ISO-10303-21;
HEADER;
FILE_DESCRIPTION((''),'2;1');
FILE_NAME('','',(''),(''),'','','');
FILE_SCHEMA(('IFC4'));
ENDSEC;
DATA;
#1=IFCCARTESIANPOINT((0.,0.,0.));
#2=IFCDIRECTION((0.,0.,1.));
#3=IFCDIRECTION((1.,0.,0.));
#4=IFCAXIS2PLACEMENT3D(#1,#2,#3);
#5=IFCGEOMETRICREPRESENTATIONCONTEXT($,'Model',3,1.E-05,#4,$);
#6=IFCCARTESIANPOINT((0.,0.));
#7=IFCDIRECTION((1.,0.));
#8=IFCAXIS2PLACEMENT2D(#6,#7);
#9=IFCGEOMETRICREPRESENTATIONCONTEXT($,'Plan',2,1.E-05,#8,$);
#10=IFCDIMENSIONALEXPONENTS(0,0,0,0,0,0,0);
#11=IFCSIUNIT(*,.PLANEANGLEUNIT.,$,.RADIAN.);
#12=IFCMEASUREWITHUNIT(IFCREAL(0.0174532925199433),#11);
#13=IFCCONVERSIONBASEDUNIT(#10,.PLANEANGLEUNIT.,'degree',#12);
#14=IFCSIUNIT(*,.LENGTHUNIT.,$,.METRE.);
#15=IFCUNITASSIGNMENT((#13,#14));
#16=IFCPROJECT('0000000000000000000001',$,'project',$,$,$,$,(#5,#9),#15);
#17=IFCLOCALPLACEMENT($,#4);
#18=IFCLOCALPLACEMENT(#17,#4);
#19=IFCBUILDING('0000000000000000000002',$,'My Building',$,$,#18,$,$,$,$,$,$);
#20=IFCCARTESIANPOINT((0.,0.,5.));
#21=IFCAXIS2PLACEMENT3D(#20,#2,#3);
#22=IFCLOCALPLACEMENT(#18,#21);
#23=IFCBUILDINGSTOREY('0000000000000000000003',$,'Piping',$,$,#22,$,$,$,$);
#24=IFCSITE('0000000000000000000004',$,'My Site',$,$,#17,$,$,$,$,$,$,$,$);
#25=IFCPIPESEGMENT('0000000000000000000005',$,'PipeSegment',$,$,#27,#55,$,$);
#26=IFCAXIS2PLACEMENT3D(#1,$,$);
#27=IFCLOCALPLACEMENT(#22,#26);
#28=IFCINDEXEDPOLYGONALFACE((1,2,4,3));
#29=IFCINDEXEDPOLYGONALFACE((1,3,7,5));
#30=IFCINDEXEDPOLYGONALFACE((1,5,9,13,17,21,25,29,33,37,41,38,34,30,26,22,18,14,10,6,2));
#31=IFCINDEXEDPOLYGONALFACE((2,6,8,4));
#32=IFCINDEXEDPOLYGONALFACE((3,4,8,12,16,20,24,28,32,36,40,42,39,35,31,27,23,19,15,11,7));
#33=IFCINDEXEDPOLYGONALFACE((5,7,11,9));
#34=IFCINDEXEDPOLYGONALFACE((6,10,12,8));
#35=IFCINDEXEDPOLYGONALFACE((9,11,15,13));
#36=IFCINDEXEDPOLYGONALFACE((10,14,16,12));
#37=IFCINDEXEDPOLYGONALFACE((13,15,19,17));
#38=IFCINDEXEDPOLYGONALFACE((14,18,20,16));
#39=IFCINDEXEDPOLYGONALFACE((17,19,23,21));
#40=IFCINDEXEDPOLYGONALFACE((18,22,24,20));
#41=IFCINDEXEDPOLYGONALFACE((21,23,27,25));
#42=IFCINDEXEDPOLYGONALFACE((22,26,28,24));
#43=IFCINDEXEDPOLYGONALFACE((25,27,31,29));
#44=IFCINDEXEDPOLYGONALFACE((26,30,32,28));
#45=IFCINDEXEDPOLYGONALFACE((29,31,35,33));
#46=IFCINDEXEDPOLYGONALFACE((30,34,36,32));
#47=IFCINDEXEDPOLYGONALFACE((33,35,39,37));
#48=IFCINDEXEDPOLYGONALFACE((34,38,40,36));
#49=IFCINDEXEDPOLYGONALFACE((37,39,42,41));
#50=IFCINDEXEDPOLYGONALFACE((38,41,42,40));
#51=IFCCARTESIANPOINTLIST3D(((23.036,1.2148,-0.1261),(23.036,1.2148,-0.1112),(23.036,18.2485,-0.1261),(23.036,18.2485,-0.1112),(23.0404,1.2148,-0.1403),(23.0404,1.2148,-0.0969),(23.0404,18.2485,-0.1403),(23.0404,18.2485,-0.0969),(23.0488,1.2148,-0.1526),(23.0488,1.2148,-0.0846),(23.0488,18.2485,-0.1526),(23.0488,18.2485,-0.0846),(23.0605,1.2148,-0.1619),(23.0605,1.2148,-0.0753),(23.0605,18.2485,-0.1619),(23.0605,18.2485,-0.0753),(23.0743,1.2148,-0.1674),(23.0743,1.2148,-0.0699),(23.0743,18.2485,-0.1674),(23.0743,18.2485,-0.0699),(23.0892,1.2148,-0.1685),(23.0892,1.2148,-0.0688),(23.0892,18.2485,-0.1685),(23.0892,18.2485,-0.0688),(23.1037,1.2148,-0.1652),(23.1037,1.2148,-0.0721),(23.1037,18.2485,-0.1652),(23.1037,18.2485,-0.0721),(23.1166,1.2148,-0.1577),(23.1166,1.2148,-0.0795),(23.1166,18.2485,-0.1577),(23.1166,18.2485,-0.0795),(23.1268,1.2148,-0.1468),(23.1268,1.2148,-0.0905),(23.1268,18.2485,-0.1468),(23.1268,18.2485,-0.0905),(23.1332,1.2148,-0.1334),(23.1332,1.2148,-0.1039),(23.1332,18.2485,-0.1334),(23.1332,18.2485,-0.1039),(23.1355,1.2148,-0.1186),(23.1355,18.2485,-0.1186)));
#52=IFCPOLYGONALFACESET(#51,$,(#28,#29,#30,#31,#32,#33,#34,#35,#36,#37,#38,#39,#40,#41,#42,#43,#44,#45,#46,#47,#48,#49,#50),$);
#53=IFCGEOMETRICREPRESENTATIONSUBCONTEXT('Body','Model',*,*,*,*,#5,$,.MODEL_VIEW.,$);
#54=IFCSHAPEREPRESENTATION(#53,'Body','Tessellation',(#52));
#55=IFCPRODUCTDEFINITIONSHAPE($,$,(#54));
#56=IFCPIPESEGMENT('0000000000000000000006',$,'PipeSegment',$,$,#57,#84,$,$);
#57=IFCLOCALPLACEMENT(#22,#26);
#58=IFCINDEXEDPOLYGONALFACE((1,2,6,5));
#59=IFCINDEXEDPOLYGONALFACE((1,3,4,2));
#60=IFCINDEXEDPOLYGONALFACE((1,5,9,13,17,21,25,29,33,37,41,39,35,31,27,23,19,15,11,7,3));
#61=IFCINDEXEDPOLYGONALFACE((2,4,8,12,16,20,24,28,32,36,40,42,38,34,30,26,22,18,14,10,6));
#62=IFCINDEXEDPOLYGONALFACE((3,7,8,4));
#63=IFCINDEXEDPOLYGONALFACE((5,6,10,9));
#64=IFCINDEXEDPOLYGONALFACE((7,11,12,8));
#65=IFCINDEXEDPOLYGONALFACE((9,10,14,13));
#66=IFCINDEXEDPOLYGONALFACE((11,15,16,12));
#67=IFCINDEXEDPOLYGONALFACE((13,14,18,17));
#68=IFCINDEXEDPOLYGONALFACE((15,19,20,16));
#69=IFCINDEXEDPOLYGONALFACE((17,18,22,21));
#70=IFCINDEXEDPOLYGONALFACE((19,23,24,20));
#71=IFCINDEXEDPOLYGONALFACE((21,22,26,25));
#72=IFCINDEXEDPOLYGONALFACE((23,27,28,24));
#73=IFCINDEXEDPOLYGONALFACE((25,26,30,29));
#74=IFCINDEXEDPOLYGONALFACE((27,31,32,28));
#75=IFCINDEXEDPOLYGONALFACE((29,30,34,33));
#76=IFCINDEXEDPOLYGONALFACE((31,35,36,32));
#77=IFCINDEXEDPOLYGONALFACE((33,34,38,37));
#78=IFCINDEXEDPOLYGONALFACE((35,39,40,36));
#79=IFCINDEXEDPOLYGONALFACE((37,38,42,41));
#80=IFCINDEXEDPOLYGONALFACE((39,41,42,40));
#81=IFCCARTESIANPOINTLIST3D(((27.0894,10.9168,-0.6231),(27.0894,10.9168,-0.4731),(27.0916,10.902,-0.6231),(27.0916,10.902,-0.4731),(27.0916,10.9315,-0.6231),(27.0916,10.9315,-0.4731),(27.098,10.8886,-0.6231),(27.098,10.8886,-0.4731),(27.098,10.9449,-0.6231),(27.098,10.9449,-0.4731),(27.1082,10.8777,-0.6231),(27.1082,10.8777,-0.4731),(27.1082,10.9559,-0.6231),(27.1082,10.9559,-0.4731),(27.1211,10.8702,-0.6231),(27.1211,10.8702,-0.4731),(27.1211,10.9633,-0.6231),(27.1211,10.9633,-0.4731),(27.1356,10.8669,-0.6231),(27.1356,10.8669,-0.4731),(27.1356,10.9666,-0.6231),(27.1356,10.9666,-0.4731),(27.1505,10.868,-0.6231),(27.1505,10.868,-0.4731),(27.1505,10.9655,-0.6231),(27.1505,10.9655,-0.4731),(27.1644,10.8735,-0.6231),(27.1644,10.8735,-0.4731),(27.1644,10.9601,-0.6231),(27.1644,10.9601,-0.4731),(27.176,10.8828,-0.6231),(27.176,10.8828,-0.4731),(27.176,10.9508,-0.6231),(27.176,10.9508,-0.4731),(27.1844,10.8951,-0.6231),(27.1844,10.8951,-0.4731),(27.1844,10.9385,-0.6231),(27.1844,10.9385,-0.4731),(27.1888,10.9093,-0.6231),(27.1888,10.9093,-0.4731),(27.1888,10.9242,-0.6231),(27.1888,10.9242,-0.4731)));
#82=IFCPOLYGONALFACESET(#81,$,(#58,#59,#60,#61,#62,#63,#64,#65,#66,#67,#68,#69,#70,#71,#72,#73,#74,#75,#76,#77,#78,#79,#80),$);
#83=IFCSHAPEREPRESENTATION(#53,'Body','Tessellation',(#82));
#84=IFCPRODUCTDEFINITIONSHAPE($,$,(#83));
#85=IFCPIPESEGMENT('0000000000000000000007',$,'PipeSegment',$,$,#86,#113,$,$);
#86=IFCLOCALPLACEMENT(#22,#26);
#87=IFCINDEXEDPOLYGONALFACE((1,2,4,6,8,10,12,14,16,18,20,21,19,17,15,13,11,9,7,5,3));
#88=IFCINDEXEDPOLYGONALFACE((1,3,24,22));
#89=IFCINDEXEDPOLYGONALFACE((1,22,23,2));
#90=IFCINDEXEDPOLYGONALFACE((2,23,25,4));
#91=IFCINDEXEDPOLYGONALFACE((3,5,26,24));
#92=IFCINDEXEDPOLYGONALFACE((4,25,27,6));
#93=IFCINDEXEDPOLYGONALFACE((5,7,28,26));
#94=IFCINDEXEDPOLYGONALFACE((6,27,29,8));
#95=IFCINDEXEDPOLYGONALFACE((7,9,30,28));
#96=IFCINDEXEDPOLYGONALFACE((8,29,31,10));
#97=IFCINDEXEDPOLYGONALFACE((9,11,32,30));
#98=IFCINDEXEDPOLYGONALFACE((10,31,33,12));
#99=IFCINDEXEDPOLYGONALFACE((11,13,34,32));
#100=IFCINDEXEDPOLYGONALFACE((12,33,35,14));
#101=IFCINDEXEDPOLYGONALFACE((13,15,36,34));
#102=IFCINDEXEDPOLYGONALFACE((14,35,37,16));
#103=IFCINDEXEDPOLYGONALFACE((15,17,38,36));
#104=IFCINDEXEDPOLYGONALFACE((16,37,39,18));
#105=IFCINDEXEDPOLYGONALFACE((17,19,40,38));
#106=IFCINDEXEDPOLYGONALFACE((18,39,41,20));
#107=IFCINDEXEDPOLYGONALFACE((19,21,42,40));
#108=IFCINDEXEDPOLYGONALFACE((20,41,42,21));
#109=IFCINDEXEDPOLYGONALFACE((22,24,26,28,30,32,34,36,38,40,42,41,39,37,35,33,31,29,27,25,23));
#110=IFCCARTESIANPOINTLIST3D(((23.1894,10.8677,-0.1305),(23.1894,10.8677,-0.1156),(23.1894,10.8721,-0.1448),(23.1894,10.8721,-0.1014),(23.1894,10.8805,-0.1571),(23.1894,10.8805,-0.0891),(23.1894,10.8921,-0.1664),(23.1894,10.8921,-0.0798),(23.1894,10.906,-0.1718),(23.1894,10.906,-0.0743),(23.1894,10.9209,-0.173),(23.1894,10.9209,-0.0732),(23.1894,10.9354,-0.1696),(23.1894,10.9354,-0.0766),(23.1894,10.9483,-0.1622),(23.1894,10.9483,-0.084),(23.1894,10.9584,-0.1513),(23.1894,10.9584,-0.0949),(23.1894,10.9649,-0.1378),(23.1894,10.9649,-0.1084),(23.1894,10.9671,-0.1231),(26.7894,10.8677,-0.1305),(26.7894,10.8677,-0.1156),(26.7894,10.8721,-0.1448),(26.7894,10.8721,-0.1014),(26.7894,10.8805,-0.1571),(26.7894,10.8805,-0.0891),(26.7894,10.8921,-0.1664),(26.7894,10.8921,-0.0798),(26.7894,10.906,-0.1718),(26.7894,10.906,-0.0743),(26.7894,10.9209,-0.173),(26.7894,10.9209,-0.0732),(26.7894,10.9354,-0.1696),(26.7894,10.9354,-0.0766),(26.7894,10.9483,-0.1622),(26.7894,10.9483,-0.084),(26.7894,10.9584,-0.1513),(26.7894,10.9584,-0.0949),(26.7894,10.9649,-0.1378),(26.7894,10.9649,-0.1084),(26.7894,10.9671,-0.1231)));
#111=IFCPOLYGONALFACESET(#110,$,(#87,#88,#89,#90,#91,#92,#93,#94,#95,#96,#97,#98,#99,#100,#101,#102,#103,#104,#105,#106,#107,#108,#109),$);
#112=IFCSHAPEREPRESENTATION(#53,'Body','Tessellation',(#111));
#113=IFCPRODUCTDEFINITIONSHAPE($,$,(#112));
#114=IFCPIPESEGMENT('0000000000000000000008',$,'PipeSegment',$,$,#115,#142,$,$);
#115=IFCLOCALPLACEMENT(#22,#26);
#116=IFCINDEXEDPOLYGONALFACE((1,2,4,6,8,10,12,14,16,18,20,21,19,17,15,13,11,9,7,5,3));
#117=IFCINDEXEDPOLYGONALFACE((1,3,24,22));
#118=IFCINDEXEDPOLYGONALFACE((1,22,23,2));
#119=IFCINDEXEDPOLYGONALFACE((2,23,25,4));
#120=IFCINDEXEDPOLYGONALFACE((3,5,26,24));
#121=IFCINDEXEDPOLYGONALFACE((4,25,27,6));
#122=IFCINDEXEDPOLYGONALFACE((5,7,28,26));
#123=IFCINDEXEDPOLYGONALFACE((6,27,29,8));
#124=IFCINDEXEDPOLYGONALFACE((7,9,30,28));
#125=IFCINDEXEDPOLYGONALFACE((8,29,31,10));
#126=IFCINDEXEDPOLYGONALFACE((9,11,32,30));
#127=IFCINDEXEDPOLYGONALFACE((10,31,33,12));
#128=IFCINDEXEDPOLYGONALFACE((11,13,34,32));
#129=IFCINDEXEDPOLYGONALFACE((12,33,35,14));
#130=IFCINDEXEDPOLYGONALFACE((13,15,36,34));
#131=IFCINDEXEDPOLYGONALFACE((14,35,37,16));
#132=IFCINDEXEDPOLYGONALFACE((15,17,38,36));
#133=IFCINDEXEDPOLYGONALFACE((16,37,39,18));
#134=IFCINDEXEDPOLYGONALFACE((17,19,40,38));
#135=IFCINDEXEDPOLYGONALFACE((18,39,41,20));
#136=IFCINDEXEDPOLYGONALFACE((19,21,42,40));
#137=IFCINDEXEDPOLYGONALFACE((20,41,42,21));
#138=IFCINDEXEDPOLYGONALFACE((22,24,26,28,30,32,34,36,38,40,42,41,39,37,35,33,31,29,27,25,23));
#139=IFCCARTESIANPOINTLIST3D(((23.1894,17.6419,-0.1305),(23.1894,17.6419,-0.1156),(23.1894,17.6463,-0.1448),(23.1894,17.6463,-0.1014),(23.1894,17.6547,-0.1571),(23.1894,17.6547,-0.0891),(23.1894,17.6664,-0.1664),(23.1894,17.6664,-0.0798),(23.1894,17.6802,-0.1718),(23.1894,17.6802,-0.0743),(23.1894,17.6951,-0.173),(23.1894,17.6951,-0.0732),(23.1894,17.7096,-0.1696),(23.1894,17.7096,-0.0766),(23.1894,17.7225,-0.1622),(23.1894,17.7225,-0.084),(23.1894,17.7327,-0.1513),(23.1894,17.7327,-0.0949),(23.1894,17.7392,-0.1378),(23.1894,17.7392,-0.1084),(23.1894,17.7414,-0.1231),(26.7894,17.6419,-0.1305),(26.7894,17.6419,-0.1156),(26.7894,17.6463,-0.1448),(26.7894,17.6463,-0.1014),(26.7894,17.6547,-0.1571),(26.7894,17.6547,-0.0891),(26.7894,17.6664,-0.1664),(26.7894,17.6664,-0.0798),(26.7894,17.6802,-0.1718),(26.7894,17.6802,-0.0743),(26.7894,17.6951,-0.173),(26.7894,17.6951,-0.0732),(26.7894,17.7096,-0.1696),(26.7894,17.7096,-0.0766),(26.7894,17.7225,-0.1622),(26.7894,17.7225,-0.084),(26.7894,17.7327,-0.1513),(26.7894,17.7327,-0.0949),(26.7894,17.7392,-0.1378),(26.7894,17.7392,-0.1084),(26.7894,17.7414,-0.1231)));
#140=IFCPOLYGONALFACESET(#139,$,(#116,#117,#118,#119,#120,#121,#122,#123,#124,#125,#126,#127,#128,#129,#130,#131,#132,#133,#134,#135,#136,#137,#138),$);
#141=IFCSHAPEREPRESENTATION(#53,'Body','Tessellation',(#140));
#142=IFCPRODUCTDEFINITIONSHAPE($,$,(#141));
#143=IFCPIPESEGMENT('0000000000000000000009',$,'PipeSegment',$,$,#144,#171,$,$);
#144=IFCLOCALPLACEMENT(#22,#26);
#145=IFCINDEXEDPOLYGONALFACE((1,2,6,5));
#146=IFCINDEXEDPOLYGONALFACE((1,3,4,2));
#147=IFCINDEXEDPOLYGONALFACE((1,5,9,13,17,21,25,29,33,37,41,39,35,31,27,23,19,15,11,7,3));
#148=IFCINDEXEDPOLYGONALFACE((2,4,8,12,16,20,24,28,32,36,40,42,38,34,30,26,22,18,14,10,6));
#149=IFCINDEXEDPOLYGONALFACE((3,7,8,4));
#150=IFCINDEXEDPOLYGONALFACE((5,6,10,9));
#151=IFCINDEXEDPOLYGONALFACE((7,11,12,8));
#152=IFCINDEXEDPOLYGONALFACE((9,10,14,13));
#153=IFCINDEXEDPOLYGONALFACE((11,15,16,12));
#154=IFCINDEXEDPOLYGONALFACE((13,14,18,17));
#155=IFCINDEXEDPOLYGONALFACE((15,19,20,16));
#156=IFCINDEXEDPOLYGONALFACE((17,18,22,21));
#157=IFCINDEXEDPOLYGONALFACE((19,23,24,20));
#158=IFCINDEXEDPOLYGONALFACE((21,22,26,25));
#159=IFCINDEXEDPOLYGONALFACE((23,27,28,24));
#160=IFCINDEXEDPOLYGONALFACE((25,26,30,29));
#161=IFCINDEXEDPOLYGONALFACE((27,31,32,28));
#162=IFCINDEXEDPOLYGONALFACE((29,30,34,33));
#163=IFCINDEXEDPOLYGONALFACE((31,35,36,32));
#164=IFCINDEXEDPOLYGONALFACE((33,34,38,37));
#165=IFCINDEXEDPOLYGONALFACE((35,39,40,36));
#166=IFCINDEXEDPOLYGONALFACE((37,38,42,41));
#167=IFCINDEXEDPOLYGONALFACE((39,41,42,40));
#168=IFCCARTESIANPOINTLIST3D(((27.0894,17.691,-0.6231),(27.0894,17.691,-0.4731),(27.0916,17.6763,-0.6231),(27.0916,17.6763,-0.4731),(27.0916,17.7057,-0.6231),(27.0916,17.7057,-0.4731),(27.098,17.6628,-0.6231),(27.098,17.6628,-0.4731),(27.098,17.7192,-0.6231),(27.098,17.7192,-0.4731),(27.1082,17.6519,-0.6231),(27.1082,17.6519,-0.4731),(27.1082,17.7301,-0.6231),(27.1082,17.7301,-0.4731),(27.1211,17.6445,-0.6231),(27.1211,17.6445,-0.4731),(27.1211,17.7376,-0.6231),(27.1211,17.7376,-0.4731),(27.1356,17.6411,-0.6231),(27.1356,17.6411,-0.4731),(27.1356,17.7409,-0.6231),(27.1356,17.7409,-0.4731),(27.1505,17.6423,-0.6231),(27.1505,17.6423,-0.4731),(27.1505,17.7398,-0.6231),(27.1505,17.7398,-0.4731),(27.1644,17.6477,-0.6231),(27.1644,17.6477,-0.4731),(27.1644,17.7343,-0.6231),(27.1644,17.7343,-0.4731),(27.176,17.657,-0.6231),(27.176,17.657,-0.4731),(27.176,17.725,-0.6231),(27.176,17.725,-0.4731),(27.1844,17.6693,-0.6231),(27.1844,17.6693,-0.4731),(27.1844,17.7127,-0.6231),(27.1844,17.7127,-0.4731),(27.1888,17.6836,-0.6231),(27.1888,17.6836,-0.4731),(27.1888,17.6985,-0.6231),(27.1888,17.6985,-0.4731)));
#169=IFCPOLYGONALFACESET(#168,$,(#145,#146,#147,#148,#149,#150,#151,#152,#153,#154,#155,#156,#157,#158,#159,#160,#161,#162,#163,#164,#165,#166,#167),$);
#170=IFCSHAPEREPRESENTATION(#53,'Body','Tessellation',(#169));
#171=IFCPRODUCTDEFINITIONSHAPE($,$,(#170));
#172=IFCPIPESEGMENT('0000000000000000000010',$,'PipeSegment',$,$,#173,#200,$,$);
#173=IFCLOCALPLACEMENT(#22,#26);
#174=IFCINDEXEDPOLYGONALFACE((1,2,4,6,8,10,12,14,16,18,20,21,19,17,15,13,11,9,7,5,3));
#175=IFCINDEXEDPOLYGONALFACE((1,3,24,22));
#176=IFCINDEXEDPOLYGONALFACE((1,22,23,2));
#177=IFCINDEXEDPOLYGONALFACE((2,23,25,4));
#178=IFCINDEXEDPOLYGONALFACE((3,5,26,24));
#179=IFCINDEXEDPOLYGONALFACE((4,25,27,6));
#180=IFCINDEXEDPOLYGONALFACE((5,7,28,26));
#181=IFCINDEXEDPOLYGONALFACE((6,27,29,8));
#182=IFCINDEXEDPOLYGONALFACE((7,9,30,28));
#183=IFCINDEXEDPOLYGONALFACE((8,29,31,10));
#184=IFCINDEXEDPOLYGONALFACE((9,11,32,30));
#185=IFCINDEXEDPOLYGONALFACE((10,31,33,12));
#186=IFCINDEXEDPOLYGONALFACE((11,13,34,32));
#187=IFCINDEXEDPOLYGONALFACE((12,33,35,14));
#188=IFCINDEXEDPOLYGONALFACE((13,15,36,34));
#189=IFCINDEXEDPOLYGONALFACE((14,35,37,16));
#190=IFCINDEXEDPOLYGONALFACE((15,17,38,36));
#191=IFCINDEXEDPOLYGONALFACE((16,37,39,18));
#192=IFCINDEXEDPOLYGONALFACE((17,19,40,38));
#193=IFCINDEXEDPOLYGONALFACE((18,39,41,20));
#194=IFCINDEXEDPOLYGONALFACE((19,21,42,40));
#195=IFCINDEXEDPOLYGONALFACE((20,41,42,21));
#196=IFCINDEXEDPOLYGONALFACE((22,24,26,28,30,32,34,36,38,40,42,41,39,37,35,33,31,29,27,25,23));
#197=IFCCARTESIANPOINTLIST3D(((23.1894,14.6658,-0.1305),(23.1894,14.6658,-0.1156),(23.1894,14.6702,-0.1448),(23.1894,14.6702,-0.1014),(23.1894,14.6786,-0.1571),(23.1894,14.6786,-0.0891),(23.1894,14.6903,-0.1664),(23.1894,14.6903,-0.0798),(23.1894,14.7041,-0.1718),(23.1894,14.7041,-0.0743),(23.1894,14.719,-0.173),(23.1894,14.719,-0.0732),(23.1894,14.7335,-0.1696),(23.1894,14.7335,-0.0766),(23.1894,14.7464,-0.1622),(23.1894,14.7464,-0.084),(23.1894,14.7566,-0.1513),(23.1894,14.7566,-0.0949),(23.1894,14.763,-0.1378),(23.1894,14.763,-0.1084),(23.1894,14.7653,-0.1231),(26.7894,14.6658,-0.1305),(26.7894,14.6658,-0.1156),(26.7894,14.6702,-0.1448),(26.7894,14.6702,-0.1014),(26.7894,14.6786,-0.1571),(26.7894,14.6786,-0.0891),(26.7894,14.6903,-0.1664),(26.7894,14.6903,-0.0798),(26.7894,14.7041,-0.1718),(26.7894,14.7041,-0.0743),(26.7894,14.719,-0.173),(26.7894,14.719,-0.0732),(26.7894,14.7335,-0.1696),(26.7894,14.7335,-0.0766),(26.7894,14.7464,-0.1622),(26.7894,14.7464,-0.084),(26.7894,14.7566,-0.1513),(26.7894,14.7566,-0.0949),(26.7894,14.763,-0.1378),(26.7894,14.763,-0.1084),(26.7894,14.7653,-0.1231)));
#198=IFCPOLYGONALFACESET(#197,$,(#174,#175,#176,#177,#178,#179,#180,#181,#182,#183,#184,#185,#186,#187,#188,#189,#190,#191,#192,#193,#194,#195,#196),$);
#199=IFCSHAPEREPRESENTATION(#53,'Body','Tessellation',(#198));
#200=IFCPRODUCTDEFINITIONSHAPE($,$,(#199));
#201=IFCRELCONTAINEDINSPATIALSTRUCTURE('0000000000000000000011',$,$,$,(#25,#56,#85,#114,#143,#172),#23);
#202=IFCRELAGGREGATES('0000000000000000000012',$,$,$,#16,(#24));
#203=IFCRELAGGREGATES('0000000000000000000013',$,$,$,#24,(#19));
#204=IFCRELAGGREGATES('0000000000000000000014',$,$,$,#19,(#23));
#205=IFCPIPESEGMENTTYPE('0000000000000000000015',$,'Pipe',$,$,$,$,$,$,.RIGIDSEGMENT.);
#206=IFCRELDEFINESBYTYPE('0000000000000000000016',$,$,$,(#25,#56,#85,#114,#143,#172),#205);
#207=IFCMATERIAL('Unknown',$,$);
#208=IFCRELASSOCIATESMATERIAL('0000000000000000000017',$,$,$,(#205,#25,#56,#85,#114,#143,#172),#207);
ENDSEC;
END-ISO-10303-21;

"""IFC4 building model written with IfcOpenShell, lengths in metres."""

from ifc_helpers import new_model, entity, si_unit, converted_unit, frame, origin_with_axes, origin_2d_with_axis, place, context, subcontext, project, spatial, circle, extrude, material, material_profile, profile_set, profile_usage, type_object, element, save


model = new_model("IFC4")

# Units and contexts
model_context = context("Model", 3, precision=1e-05, world=origin_with_axes())
plan_context = context("Plan", 2, precision=1e-05, world=origin_2d_with_axis())
body_context = subcontext(model_context, "Body", "Model", "MODEL_VIEW")
ifc_project = project(units=[converted_unit("PLANEANGLEUNIT", "degree", entity("IfcReal", 0.0174532925199433), si_unit("PLANEANGLEUNIT", "RADIAN"), dimensions=[0, 0, 0, 0, 0, 0, 0]), si_unit("LENGTHUNIT", "METRE")], contexts=[model_context, plan_context])

# Site, building, storey
site_placement = place(None, origin_with_axes())
site = spatial("IfcSite", under=ifc_project, at=site_placement, Name="My Site")
building_placement = place(site_placement, origin_with_axes())
building = spatial("IfcBuilding", under=site, at=building_placement, Name="My Building")
storey_placement = place(building_placement, frame((0.0, 0.0, 5.0), z_axis=(0.0, 0.0, 1.0), x_axis=(1.0, 0.0, 0.0)))
storey = spatial("IfcBuildingStorey", under=building, at=storey_placement, Name="Piping")

# Pipe segments
ifc_material = material(Name="Unknown")
ifc_material_profile_1 = material_profile(ifc_material, circle(Radius=0.05))
ifc_profile_set_1 = profile_set([ifc_material_profile_1])
ifc_profile_usage_1 = profile_usage(ifc_profile_set_1, cardinal=5)
pipe_segment_type = type_object("IfcPipeSegmentType", Name="Pipe", PredefinedType="RIGIDSEGMENT", material=ifc_profile_set_1)
pipe_segment_1_placement = place(storey_placement, frame((23.0855, 18.2485, -0.1186), z_axis=(0.0, -1.0, -0.000001), x_axis=(1.0, 0.0, 0.0)))
element("IfcPipeSegment", 1, at=pipe_segment_1_placement, inside=storey, type_object=pipe_segment_type, material=ifc_profile_usage_1, Name="PipeSegment", context=body_context, shape_type="SweptSolid", body=[
    extrude(circle(Radius=0.05), origin_with_axes(), (0.0, 0.0, 1.0), 17.0337),
])
ifc_profile_usage_2 = profile_usage(ifc_profile_set_1, cardinal=5)
pipe_segment_2_placement = place(storey_placement, frame((27.1394, 10.9168, -0.4731), z_axis=(0.0, 0.0, -1.0), x_axis=(-1.0, 0.0, 0.0)))
element("IfcPipeSegment", 2, at=pipe_segment_2_placement, inside=storey, type_object=pipe_segment_type, material=ifc_profile_usage_2, Name="PipeSegment", context=body_context, shape_type="SweptSolid", body=[
    extrude(circle(Radius=0.05), origin_with_axes(), (0.0, 0.0, 1.0), 0.15),
])
ifc_profile_usage_3 = profile_usage(ifc_profile_set_1, cardinal=5)
pipe_segment_3_placement = place(storey_placement, frame((23.1894, 10.9171, -0.1231), z_axis=(1.0, 0.0, 0.0), x_axis=(0.0, 1.0, 0.0)))
element("IfcPipeSegment", 3, at=pipe_segment_3_placement, inside=storey, type_object=pipe_segment_type, material=ifc_profile_usage_3, Name="PipeSegment", context=body_context, shape_type="SweptSolid", body=[
    extrude(circle(Radius=0.05), origin_with_axes(), (0.0, 0.0, 1.0), 3.6),
])
ifc_profile_usage_4 = profile_usage(ifc_profile_set_1, cardinal=5)
pipe_segment_4_placement = place(storey_placement, frame((23.1894, 17.6914, -0.1231), z_axis=(1.0, 0.0, 0.0), x_axis=(0.0, 1.0, 0.0)))
element("IfcPipeSegment", 4, at=pipe_segment_4_placement, inside=storey, type_object=pipe_segment_type, material=ifc_profile_usage_4, Name="PipeSegment", context=body_context, shape_type="SweptSolid", body=[
    extrude(circle(Radius=0.05), origin_with_axes(), (0.0, 0.0, 1.0), 3.6),
])
ifc_profile_usage_5 = profile_usage(ifc_profile_set_1, cardinal=5)
pipe_segment_5_placement = place(storey_placement, frame((27.1394, 17.691, -0.4731), z_axis=(0.0, 0.0, -1.0), x_axis=(-1.0, 0.0, 0.0)))
element("IfcPipeSegment", 5, at=pipe_segment_5_placement, inside=storey, type_object=pipe_segment_type, material=ifc_profile_usage_5, Name="PipeSegment", context=body_context, shape_type="SweptSolid", body=[
    extrude(circle(Radius=0.05), origin_with_axes(), (0.0, 0.0, 1.0), 0.15),
])
ifc_profile_usage_6 = profile_usage(ifc_profile_set_1, cardinal=5)
pipe_segment_6_placement = place(storey_placement, frame((23.1894, 14.7153, -0.1231), z_axis=(1.0, 0.0, 0.0), x_axis=(0.0, 1.0, 0.0)))
element("IfcPipeSegment", 6, at=pipe_segment_6_placement, inside=storey, type_object=pipe_segment_type, material=ifc_profile_usage_6, Name="PipeSegment", context=body_context, shape_type="SweptSolid", body=[
    extrude(circle(Radius=0.05), origin_with_axes(), (0.0, 0.0, 1.0), 3.6),
])

save(model, "model.ifc")
